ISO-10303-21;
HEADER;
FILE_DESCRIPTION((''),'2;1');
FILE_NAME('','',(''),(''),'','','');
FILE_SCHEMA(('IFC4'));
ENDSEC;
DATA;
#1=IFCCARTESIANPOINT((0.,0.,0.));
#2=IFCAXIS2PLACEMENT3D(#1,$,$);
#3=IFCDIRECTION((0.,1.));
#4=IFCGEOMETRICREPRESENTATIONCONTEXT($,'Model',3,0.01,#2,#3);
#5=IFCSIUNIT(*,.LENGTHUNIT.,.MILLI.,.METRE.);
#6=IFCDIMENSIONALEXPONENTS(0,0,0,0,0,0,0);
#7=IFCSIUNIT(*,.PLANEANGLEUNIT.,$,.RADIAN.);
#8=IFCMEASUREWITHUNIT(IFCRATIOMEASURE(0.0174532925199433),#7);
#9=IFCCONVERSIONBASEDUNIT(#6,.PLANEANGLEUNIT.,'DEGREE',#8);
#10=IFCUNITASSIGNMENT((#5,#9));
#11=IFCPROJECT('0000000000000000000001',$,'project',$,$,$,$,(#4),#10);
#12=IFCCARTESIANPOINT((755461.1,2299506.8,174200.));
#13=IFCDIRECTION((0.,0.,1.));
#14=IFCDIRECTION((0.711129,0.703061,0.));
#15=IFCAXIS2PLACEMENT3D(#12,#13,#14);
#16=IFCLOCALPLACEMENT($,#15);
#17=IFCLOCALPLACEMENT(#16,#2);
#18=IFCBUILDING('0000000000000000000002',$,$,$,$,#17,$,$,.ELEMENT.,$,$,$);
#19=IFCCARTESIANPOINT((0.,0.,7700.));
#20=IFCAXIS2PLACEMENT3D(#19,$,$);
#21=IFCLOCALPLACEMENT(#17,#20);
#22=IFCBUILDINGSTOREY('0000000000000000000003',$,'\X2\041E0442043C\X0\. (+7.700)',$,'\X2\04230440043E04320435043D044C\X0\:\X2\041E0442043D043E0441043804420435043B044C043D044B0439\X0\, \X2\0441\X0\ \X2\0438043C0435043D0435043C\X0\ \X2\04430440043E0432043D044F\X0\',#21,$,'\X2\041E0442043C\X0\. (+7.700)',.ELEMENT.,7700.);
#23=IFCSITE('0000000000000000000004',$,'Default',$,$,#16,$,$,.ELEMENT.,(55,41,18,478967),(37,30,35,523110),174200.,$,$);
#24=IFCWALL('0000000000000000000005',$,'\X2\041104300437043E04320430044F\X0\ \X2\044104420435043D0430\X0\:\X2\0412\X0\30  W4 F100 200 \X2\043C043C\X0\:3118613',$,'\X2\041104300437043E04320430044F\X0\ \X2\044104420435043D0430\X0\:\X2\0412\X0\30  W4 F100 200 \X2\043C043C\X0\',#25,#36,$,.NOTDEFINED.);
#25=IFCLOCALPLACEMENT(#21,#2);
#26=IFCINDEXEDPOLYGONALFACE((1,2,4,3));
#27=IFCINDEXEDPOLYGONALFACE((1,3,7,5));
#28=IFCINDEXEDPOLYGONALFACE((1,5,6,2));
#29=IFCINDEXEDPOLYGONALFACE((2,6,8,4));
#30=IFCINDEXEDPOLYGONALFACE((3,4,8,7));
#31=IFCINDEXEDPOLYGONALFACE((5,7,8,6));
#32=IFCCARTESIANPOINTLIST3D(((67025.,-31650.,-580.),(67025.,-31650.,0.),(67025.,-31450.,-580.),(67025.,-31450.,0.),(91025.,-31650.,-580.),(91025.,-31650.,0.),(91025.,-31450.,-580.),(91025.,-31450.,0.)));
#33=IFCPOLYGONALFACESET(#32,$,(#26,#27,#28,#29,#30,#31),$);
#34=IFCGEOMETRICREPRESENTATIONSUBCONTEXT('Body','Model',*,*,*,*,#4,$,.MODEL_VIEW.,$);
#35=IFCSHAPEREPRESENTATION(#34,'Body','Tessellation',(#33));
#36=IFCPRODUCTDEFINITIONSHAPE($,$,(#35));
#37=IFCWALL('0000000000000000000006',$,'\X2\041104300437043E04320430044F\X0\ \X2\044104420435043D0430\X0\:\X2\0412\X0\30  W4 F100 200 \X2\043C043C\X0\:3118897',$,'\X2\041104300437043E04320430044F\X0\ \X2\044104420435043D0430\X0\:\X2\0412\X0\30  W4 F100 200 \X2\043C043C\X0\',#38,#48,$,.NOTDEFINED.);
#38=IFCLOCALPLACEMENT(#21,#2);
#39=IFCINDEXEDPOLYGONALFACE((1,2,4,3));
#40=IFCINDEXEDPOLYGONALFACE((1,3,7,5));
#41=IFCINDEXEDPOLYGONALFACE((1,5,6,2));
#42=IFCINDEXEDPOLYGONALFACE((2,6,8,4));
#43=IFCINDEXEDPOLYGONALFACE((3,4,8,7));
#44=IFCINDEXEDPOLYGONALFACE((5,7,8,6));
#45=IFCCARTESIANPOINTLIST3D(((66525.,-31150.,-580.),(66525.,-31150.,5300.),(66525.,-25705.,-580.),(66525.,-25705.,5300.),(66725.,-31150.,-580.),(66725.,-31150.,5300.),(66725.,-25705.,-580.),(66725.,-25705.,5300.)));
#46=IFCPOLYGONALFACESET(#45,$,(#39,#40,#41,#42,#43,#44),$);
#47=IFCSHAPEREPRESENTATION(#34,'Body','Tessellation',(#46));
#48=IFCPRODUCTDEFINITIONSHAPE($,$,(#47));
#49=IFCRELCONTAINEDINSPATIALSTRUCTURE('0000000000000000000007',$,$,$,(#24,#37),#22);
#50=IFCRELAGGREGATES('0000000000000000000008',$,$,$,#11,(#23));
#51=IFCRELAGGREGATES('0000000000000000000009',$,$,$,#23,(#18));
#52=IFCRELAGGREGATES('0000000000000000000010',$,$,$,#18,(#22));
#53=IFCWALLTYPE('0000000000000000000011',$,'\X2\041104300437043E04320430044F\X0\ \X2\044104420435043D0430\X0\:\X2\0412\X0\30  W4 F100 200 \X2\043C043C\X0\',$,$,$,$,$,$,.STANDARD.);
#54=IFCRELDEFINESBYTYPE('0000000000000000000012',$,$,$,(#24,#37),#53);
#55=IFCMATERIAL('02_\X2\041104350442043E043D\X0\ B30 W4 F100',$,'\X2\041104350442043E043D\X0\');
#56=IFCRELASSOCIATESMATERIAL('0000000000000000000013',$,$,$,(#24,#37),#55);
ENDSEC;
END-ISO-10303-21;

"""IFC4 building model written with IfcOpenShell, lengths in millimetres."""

from ifc_helpers import new_model, entity, si_unit, converted_unit, direction, frame, origin, place, context, subcontext, project, spatial, indexed_curve, outline, extrude, material, type_object, element, save


model = new_model("IFC4")

# Units and contexts
model_context = context("Model", 3, precision=0.01, world=origin(), true_north=direction((0.0, 1.0)))
body_context = subcontext(model_context, "Body", "Model", "MODEL_VIEW")
ifc_project = project(units=[si_unit("LENGTHUNIT", "METRE", prefix="MILLI"), converted_unit("PLANEANGLEUNIT", "DEGREE", entity("IfcRatioMeasure", 0.0174532925199433), si_unit("PLANEANGLEUNIT", "RADIAN"), dimensions=[0, 0, 0, 0, 0, 0, 0])], contexts=[model_context])

# Site, building, storey
site_placement = place(None, frame((755461.1, 2299506.8, 174200.0), z_axis=(0.0, 0.0, 1.0), x_axis=(0.711129, 0.703061, 0.0)))
site = spatial("IfcSite", under=ifc_project, at=site_placement, Name="Default", CompositionType="ELEMENT", RefLatitude=(55, 41, 18, 478967), RefLongitude=(37, 30, 35, 523110), RefElevation=174200.0)
building_placement = place(site_placement, origin())
building = spatial("IfcBuilding", under=site, at=building_placement, CompositionType="ELEMENT")
storey_placement = place(building_placement, frame((0.0, 0.0, 7700.0)))
storey = spatial("IfcBuildingStorey", under=building, at=storey_placement, Name="Отм. (+7.700)", ObjectType="Уровень:Относительный, с именем уровня", LongName="Отм. (+7.700)", CompositionType="ELEMENT", Elevation=7700.0)

# Shared definitions
ifc_material_1 = material(Name="02_Бетон B30 W4 F100", Category="Бетон")

# Walls
wall_type = type_object("IfcWallType", Name="Базовая стена:В30  W4 F100 200 мм", PredefinedType="STANDARD")
wall_1_placement = place(storey_placement, frame((91025.0, -31550.0, -580.0), z_axis=(0.0, 0.0, 1.0), x_axis=(-1.0, 0.0, 0.0)))
element("IfcWall", 1, at=wall_1_placement, inside=storey, type_object=wall_type, material=ifc_material_1, Name="Базовая стена:В30  W4 F100 200 мм:3118613", ObjectType="Базовая стена:В30  W4 F100 200 мм", PredefinedType="NOTDEFINED", context=body_context, shape_type="SweptSolid", body=[
    extrude(outline(indexed_curve([(24000.0, 100.0), (0.0, 100.0), (0.0, -100.0), (24000.0, -100.0), (24000.0, 100.0)], self_intersect=False)), origin(), (0.0, 0.0, 1.0), 580.0),
])
wall_2_placement = place(storey_placement, frame((66625.0, -31150.0, -580.0), z_axis=(0.0, 0.0, 1.0), x_axis=(0.0, 1.0, 0.0)))
element("IfcWall", 2, at=wall_2_placement, inside=storey, type_object=wall_type, material=ifc_material_1, Name="Базовая стена:В30  W4 F100 200 мм:3118897", ObjectType="Базовая стена:В30  W4 F100 200 мм", PredefinedType="NOTDEFINED", context=body_context, shape_type="SweptSolid", body=[
    extrude(outline(indexed_curve([(5445.0, 100.0), (0.0, 100.0), (0.0, -100.0), (5445.0, -100.0), (5445.0, 100.0)], self_intersect=False)), origin(), (0.0, 0.0, 1.0), 5880.0),
])

save(model, "model.ifc")
